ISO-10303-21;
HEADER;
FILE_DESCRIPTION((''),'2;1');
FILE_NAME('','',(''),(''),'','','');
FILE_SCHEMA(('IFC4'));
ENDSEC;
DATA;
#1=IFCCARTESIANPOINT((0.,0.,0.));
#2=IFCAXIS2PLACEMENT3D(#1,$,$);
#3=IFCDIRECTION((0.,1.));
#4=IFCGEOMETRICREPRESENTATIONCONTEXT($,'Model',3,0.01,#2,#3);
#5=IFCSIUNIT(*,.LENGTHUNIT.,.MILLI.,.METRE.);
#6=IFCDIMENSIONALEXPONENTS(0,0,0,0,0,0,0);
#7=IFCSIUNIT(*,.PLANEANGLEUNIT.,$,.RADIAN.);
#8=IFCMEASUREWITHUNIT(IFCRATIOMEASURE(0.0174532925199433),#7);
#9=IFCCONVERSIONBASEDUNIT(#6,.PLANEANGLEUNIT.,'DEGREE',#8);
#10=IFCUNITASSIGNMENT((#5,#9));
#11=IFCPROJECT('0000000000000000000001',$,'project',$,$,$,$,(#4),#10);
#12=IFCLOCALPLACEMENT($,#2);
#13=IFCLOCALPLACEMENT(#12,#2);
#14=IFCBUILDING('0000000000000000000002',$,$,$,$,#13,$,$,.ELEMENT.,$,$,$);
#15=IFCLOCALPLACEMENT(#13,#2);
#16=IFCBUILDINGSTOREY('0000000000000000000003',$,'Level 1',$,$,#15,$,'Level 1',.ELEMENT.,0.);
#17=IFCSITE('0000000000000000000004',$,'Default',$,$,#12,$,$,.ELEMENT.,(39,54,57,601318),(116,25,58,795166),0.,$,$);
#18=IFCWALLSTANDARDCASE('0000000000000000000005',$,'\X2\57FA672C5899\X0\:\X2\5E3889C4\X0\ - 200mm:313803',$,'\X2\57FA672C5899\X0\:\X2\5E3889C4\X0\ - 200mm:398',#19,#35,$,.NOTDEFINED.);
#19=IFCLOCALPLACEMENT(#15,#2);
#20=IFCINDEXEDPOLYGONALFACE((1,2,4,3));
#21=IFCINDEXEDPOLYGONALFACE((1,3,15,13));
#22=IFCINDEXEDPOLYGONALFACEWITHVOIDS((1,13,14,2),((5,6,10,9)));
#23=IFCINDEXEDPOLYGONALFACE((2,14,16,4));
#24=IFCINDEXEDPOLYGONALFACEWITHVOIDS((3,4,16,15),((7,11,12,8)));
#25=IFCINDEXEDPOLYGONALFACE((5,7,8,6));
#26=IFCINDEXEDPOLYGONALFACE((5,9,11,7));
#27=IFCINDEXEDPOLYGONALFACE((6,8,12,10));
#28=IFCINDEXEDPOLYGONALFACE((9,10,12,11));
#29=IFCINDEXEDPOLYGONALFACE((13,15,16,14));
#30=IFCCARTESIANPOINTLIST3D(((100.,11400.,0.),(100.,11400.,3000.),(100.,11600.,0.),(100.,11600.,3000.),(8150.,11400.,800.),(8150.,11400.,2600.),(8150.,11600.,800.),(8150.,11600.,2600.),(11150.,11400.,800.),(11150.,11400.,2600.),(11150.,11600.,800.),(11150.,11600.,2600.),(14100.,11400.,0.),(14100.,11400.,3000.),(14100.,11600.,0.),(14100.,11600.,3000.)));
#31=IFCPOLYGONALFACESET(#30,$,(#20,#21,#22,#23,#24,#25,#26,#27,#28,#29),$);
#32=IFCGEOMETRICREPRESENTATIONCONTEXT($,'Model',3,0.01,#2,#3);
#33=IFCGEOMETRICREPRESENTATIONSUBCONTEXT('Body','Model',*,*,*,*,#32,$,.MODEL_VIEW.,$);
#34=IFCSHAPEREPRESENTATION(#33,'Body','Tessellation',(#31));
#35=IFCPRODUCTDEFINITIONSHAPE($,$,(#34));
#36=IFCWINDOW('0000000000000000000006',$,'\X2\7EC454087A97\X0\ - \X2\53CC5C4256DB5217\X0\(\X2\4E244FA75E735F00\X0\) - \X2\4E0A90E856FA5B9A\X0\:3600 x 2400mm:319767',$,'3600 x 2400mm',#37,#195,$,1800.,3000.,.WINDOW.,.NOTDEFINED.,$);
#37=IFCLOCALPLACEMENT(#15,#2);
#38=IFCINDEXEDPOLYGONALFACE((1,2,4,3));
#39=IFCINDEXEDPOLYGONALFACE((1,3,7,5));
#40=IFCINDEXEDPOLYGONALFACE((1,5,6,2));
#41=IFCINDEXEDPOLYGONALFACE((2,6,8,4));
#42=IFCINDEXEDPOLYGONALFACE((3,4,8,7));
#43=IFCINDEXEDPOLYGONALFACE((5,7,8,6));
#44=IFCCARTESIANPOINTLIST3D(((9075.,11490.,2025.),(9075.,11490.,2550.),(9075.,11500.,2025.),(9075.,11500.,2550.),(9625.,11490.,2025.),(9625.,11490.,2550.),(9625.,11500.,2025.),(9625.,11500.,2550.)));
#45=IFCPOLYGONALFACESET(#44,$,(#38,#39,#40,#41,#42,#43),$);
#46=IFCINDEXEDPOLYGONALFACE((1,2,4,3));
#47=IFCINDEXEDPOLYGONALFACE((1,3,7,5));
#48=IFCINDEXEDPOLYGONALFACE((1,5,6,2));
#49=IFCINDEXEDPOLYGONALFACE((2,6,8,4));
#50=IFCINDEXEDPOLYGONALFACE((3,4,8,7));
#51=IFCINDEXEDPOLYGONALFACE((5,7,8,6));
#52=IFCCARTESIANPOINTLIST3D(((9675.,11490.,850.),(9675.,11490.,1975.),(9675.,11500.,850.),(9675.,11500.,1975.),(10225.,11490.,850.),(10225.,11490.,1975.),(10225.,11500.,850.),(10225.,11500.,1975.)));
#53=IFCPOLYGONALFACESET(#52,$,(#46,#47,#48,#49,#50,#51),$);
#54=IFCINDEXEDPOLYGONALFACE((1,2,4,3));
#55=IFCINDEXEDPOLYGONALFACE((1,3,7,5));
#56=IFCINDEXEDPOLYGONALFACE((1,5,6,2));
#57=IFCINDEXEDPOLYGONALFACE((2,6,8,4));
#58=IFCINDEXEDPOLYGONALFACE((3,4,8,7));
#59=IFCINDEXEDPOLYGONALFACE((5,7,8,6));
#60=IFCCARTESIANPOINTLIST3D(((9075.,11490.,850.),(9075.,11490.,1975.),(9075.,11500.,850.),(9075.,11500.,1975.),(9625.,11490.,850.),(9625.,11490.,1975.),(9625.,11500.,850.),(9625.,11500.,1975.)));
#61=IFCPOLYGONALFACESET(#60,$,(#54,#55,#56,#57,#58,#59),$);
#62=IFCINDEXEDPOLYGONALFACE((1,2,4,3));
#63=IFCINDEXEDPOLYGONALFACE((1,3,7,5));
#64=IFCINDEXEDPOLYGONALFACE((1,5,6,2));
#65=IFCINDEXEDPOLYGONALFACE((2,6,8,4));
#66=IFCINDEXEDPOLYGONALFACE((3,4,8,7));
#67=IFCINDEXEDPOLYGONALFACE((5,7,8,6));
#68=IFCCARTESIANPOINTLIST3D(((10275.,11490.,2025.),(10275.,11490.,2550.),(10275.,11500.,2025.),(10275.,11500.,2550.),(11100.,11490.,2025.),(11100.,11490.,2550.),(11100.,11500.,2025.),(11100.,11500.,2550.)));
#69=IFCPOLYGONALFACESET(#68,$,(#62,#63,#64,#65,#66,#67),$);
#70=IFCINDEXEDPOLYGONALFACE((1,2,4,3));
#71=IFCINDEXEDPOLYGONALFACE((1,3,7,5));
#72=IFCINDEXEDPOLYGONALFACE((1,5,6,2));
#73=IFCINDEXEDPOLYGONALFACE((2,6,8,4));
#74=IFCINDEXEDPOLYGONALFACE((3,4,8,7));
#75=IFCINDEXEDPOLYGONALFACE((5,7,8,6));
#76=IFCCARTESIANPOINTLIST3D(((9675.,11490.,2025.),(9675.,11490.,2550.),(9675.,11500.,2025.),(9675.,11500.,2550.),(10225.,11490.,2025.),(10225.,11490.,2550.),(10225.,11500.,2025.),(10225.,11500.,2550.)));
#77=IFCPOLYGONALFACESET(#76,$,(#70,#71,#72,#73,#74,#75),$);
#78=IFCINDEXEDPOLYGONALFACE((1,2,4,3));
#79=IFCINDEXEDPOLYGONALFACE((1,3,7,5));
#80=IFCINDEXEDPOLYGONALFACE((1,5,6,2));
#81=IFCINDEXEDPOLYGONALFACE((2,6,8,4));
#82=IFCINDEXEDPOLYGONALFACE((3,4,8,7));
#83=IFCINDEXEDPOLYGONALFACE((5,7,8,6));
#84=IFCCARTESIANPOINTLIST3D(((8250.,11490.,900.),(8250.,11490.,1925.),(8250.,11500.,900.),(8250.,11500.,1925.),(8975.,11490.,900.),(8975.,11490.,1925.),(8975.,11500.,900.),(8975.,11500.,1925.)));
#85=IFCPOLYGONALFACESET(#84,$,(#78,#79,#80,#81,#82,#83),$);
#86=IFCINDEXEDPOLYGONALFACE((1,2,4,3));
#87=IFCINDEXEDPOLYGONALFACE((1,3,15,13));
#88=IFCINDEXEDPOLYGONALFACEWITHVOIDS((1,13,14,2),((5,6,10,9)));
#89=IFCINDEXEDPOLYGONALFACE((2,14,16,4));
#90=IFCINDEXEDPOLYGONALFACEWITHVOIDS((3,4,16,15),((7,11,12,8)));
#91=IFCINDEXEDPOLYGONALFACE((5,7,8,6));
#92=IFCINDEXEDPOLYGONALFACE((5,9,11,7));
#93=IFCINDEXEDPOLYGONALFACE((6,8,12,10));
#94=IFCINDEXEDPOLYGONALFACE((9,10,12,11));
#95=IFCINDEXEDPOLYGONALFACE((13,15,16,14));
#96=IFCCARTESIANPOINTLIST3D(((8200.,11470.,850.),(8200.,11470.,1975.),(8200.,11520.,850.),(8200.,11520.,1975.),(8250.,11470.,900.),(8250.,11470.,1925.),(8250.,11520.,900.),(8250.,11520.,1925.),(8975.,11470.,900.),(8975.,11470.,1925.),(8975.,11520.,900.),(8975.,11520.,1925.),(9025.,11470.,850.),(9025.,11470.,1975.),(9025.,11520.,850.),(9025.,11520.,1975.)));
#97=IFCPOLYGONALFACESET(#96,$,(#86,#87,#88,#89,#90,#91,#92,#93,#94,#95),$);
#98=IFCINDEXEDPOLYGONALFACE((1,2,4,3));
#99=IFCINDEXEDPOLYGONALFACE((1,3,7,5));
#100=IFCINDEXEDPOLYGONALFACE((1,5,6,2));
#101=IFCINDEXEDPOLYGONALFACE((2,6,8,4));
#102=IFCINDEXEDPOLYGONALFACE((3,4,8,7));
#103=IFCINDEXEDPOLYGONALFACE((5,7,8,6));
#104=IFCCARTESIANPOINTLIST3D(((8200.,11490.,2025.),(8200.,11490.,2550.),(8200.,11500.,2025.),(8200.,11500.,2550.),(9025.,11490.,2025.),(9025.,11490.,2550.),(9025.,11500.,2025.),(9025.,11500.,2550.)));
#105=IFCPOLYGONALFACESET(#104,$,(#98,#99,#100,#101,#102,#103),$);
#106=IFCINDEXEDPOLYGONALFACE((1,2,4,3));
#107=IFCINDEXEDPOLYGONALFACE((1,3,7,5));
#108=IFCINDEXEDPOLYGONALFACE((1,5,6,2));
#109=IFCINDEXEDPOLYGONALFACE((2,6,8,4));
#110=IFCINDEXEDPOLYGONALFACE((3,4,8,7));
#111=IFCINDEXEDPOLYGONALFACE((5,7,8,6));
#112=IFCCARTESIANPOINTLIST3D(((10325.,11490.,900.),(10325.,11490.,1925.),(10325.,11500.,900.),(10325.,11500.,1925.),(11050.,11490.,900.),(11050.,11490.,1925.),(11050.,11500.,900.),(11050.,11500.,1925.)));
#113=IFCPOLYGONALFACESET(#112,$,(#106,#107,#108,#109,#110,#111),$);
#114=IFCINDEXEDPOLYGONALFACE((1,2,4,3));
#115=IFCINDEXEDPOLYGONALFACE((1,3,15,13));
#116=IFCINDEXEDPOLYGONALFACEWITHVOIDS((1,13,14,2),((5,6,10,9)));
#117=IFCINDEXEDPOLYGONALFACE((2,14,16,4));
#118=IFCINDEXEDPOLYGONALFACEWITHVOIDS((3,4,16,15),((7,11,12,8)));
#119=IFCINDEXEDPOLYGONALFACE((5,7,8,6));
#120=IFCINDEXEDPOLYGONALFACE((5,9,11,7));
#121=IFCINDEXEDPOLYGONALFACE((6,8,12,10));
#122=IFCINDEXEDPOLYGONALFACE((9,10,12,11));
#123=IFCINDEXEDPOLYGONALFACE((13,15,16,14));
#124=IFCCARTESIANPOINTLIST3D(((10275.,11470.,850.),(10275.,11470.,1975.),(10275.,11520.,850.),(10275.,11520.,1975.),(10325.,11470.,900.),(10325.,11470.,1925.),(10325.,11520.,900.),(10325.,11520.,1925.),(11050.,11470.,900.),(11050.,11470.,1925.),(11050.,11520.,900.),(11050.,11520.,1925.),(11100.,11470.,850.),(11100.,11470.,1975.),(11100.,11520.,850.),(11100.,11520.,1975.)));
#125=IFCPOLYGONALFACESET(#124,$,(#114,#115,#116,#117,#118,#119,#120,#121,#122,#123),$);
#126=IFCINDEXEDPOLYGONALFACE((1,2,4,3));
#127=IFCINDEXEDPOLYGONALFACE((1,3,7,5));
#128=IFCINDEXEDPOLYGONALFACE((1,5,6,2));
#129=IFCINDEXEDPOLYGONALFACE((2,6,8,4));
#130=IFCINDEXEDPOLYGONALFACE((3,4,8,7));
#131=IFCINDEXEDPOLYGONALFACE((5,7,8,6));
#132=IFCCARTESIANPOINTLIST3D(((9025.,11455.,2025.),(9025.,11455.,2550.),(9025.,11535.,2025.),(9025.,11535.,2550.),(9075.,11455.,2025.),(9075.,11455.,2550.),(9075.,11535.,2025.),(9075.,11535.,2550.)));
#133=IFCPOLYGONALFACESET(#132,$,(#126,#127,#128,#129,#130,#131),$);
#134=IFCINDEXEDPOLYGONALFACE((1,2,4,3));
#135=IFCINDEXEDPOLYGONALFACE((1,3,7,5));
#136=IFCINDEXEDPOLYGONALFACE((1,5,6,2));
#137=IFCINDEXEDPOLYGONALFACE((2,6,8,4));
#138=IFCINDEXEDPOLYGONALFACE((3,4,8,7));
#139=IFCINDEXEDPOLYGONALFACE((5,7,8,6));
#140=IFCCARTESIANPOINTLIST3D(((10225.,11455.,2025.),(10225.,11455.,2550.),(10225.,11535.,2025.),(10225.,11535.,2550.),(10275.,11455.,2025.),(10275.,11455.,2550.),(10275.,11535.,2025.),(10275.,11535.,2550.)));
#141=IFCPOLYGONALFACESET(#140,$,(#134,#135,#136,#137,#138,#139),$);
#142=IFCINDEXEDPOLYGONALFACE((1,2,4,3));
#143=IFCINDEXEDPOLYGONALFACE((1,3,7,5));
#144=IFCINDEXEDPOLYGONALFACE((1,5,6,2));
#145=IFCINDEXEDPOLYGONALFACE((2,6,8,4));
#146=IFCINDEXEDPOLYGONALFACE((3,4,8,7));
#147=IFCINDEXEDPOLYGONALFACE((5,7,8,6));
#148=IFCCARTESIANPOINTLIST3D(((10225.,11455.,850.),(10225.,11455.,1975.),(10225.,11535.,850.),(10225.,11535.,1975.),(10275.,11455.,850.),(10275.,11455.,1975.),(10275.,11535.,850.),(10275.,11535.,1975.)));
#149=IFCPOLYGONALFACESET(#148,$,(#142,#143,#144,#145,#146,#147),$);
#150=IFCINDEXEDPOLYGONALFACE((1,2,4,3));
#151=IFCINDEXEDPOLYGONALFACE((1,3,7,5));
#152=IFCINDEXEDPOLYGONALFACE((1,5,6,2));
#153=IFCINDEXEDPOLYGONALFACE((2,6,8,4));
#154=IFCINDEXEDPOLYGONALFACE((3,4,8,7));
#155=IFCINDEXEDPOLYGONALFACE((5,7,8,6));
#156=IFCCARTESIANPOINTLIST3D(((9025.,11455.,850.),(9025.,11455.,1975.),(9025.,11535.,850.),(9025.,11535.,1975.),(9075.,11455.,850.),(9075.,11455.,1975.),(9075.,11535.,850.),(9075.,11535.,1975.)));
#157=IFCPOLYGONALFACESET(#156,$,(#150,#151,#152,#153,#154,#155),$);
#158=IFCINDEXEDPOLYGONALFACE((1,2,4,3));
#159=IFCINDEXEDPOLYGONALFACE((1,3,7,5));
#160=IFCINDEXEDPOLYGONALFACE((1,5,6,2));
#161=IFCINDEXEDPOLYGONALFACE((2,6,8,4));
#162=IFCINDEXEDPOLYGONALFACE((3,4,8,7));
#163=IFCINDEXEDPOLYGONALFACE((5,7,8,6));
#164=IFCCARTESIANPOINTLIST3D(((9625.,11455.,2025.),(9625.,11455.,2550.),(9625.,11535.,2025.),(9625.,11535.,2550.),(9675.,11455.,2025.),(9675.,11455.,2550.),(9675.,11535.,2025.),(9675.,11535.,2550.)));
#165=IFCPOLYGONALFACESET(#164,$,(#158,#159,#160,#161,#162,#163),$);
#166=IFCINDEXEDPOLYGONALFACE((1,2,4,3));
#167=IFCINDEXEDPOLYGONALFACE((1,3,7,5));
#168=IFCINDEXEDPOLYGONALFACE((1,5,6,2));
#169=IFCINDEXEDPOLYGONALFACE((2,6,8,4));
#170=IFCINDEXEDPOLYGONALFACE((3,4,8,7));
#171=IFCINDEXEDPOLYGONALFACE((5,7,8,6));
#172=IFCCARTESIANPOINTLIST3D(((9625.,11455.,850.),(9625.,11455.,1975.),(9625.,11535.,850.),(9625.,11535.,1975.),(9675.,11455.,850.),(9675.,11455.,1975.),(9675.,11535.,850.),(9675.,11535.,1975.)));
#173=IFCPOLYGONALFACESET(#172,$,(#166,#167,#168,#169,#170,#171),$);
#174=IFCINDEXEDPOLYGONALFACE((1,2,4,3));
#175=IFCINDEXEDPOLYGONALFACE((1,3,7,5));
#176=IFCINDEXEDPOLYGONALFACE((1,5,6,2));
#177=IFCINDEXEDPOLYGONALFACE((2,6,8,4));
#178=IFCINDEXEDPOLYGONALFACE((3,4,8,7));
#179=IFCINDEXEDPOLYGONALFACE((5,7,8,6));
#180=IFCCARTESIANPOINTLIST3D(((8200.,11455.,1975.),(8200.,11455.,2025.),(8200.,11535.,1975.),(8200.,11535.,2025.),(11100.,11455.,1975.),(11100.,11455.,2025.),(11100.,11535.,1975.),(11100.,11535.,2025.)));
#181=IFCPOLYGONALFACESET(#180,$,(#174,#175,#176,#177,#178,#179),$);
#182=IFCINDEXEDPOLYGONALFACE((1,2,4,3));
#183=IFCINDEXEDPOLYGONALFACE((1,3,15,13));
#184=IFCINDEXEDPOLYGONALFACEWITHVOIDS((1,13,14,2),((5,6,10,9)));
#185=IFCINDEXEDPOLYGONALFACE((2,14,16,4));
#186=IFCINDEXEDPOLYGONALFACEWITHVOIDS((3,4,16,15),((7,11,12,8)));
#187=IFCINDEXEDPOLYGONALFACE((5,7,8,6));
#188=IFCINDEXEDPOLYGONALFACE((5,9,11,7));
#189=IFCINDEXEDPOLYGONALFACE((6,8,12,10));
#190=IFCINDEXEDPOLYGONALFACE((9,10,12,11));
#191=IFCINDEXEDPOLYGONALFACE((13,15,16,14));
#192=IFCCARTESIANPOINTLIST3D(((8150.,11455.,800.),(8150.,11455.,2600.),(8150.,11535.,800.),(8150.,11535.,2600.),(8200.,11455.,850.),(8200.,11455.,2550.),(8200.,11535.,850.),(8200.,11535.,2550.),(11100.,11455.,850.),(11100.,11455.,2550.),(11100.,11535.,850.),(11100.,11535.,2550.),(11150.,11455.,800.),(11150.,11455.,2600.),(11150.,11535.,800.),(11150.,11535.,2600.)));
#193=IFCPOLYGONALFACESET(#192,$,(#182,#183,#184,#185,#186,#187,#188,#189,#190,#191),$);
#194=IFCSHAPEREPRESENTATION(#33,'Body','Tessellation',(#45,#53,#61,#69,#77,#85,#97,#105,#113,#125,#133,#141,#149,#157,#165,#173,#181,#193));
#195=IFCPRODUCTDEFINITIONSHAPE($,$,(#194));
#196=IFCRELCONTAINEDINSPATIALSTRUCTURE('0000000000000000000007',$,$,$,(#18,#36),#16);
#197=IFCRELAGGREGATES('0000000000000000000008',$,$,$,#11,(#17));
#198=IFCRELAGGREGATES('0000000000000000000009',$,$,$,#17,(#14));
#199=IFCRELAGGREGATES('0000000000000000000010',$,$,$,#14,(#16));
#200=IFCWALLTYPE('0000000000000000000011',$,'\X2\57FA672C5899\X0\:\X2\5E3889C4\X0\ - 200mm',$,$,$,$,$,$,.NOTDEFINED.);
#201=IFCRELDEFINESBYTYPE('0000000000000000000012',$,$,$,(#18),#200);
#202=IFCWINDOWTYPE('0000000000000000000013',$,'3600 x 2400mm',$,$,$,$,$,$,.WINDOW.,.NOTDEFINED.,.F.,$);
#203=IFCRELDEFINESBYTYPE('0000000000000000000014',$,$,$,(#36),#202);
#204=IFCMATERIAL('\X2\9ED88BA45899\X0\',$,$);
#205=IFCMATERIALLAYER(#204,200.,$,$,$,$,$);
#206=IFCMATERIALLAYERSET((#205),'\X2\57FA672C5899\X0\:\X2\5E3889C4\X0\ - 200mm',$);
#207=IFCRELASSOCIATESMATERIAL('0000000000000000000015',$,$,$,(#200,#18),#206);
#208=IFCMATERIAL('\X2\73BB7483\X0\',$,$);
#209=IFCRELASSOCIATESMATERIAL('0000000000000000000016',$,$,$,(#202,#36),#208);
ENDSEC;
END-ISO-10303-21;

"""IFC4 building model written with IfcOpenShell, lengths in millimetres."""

from ifc_helpers import new_model, entity, si_unit, converted_unit, direction, frame, frame_2d, origin, origin_2d_with_axis, place, context, subcontext, project, spatial, polyline, rectangle, outline, extrude, source, transform, mapped, material, layer, layer_set, layer_usage, type_object, type_shapes, element, fill, save


model = new_model("IFC4")

# Units and contexts
model_context_1 = context("Model", 3, precision=0.01, world=origin(), true_north=direction((0.0, 1.0)))
model_context_2 = context("Model", 3, precision=0.01, world=origin(), true_north=direction((0.0, 1.0)))
body_context = subcontext(model_context_2, "Body", "Model", "MODEL_VIEW")
ifc_project = project(units=[si_unit("LENGTHUNIT", "METRE", prefix="MILLI"), converted_unit("PLANEANGLEUNIT", "DEGREE", entity("IfcRatioMeasure", 0.0174532925199433), si_unit("PLANEANGLEUNIT", "RADIAN"), dimensions=[0, 0, 0, 0, 0, 0, 0])], contexts=[model_context_1])

# Site, building, storey
site_placement = place(None, origin())
site = spatial("IfcSite", under=ifc_project, at=site_placement, Name="Default", CompositionType="ELEMENT", RefLatitude=(39, 54, 57, 601318), RefLongitude=(116, 25, 58, 795166), RefElevation=0.0)
building_placement = place(site_placement, origin())
building = spatial("IfcBuilding", under=site, at=building_placement, CompositionType="ELEMENT")
storey_placement = place(building_placement, origin())
storey = spatial("IfcBuildingStorey", under=building, at=storey_placement, Name="Level 1", LongName="Level 1", CompositionType="ELEMENT", Elevation=0.0)

# Shared definitions
ifc_material_1 = material(Name="默认墙")
ifc_layer = layer(ifc_material_1, 200.0)
ifc_layer_set = layer_set([ifc_layer], Name="基本墙:常规 - 200mm")
wall_type = type_object("IfcWallType", Name="基本墙:常规 - 200mm", PredefinedType="NOTDEFINED", material=ifc_layer_set)
ifc_material_2 = material(Name="玻璃")
window_type_1 = type_object("IfcWindowType", Name="3600 x 2400mm", ParameterTakesPrecedence=False, PartitioningType="NOTDEFINED", PredefinedType="WINDOW", material=ifc_material_2)
shared_shape_1 = source(origin(), body_context, "Body", "SweptSolid", [
    extrude(rectangle(XDim=10.0, YDim=550.0, at=origin_2d_with_axis()), frame((1200.0, 95.0, 1225.0), z_axis=(0.0, 0.0, 1.0), x_axis=(0.0, 1.0, 0.0)), (0.0, 0.0, 1.0), 525.0),
    extrude(rectangle(XDim=10.0, YDim=550.0, at=origin_2d_with_axis()), frame((1800.0, 95.0, 50.0), z_axis=(0.0, 0.0, 1.0), x_axis=(0.0, 1.0, 0.0)), (0.0, 0.0, 1.0), 1125.0),
    extrude(rectangle(XDim=10.0, YDim=550.0, at=origin_2d_with_axis()), frame((1200.0, 95.0, 50.0), z_axis=(0.0, 0.0, 1.0), x_axis=(0.0, 1.0, 0.0)), (0.0, 0.0, 1.0), 1125.0),
    extrude(rectangle(XDim=10.0, YDim=825.0, at=origin_2d_with_axis()), frame((2537.5, 95.0, 1225.0), z_axis=(0.0, 0.0, 1.0), x_axis=(0.0, 1.0, 0.0)), (0.0, 0.0, 1.0), 525.0),
    extrude(rectangle(XDim=10.0, YDim=550.0, at=origin_2d_with_axis()), frame((1800.0, 95.0, 1225.0), z_axis=(0.0, 0.0, 1.0), x_axis=(0.0, 1.0, 0.0)), (0.0, 0.0, 1.0), 525.0),
    extrude(rectangle(XDim=10.0, YDim=725.0, at=origin_2d_with_axis()), frame((462.5, 95.0, 100.0), z_axis=(0.0, 0.0, 1.0), x_axis=(0.0, 1.0, 0.0)), (0.0, 0.0, 1.0), 1025.0),
    extrude(outline(polyline([(-562.5, -412.5), (562.5, -412.5), (562.5, 412.5), (-562.5, 412.5), (-562.5, -412.5)]), holes=[polyline([(512.5, -362.5), (-512.5, -362.5), (-512.5, 362.5), (512.5, 362.5), (512.5, -362.5)])]), frame((462.5, 70.0, 612.5), z_axis=(0.0, 1.0, 0.0), x_axis=(0.0, 0.0, -1.0)), (0.0, 0.0, 1.0), 50.0),
    extrude(rectangle(XDim=10.0, YDim=825.0, at=origin_2d_with_axis()), frame((462.5, 95.0, 1225.0), z_axis=(0.0, 0.0, 1.0), x_axis=(0.0, 1.0, 0.0)), (0.0, 0.0, 1.0), 525.0),
    extrude(rectangle(XDim=10.0, YDim=725.0, at=origin_2d_with_axis()), frame((2537.5, 95.0, 100.0), z_axis=(0.0, 0.0, 1.0), x_axis=(0.0, 1.0, 0.0)), (0.0, 0.0, 1.0), 1025.0),
    extrude(outline(polyline([(-562.5, -412.5), (562.5, -412.5), (562.5, 412.5), (-562.5, 412.5), (-562.5, -412.5)]), holes=[polyline([(512.5, -362.5), (-512.5, -362.5), (-512.5, 362.5), (512.5, 362.5), (512.5, -362.5)])]), frame((2537.5, 70.0, 612.5), z_axis=(0.0, 1.0, 0.0), x_axis=(0.0, 0.0, -1.0)), (0.0, 0.0, 1.0), 50.0),
    extrude(rectangle(XDim=80.0, YDim=50.0, at=origin_2d_with_axis()), frame((900.0, 95.0, 1225.0), z_axis=(0.0, 0.0, 1.0), x_axis=(0.0, -1.0, 0.0)), (0.0, 0.0, 1.0), 525.0),
    extrude(rectangle(XDim=80.0, YDim=50.0, at=origin_2d_with_axis()), frame((2100.0, 95.0, 1225.0), z_axis=(0.0, 0.0, 1.0), x_axis=(0.0, -1.0, 0.0)), (0.0, 0.0, 1.0), 525.0),
    extrude(rectangle(XDim=80.0, YDim=50.0, at=origin_2d_with_axis()), frame((2100.0, 95.0, 50.0), z_axis=(0.0, 0.0, 1.0), x_axis=(0.0, -1.0, 0.0)), (0.0, 0.0, 1.0), 1125.0),
    extrude(rectangle(XDim=80.0, YDim=50.0, at=origin_2d_with_axis()), frame((900.0, 95.0, 50.0), z_axis=(0.0, 0.0, 1.0), x_axis=(0.0, -1.0, 0.0)), (0.0, 0.0, 1.0), 1125.0),
    extrude(rectangle(XDim=80.0, YDim=50.0, at=origin_2d_with_axis()), frame((1500.0, 95.0, 1225.0), z_axis=(0.0, 0.0, 1.0), x_axis=(0.0, -1.0, 0.0)), (0.0, 0.0, 1.0), 525.0),
    extrude(rectangle(XDim=80.0, YDim=50.0, at=origin_2d_with_axis()), frame((1500.0, 95.0, 50.0), z_axis=(0.0, 0.0, 1.0), x_axis=(0.0, -1.0, 0.0)), (0.0, 0.0, 1.0), 1125.0),
    extrude(rectangle(XDim=80.0, YDim=2900.0, at=origin_2d_with_axis()), frame((1500.0, 95.0, 1175.0), z_axis=(0.0, 0.0, 1.0), x_axis=(0.0, -1.0, 0.0)), (0.0, 0.0, 1.0), 50.0),
    extrude(outline(polyline([(-1500.0, -900.0), (1500.0, -900.0), (1500.0, 900.0), (-1500.0, 900.0), (-1500.0, -900.0)]), holes=[polyline([(1450.0, -850.0), (-1450.0, -850.0), (-1450.0, 850.0), (1450.0, 850.0), (1450.0, -850.0)])]), frame((1500.0, 55.0, 900.0), z_axis=(0.0, 1.0, 0.0), x_axis=(1.0, 0.0, 0.0)), (0.0, 0.0, 1.0), 80.0),
])
type_shapes(window_type_1, [shared_shape_1])

# Wall, opening, window
ifc_layer_usage_1 = layer_usage(ifc_layer_set, "AXIS2", "NEGATIVE", 100.0)
wall_1_placement = place(storey_placement, frame((100.0, 11500.0, 0.0)))
wall_1 = element("IfcWallStandardCase", 1, at=wall_1_placement, inside=storey, type_object=wall_type, material=ifc_layer_usage_1, Name="基本墙:常规 - 200mm:313803", ObjectType="基本墙:常规 - 200mm:398", PredefinedType="NOTDEFINED", context=body_context, shape_type="SweptSolid", body=[
    extrude(rectangle(XDim=14000.0, YDim=200.0, at=frame_2d((7000.0, 0.0), x_axis=(-1.0, 0.0))), origin(), (0.0, 0.0, 1.0), 3000.0),
])
opening_1_placement = place(wall_1_placement, frame((8050.0, -100.0, 800.0)))
opening_1 = element("IfcOpeningElement", 2, at=opening_1_placement, cuts=wall_1, ObjectType="Opening", PredefinedType="OPENING", context=body_context, shape_type="SweptSolid", body=[
    extrude(rectangle(XDim=1800.0, YDim=3000.0, at=frame_2d((900.0, 1500.0), x_axis=(1.0, 0.0))), frame((0.0, 0.0, 0.0), z_axis=(0.0, 1.0, 0.0), x_axis=(0.0, 0.0, 1.0)), (0.0, 0.0, 1.0), 200.0),
])
window_1_placement = place(opening_1_placement, origin())
window_1 = element("IfcWindow", 3, at=window_1_placement, inside=storey, type_object=window_type_1, material=ifc_material_2, Name="组合窗 - 双层四列(两侧平开) - 上部固定:3600 x 2400mm:319767", ObjectType="3600 x 2400mm", OverallHeight=1800.0, OverallWidth=3000.0, PartitioningType="NOTDEFINED", PredefinedType="WINDOW", context=body_context, shape_type="MappedRepresentation", body=[
    mapped(shared_shape_1, transform((0.0, 0.0, 0.0), scale=1.0)),
])
fill(opening_1, window_1)

save(model, "model.ifc")
